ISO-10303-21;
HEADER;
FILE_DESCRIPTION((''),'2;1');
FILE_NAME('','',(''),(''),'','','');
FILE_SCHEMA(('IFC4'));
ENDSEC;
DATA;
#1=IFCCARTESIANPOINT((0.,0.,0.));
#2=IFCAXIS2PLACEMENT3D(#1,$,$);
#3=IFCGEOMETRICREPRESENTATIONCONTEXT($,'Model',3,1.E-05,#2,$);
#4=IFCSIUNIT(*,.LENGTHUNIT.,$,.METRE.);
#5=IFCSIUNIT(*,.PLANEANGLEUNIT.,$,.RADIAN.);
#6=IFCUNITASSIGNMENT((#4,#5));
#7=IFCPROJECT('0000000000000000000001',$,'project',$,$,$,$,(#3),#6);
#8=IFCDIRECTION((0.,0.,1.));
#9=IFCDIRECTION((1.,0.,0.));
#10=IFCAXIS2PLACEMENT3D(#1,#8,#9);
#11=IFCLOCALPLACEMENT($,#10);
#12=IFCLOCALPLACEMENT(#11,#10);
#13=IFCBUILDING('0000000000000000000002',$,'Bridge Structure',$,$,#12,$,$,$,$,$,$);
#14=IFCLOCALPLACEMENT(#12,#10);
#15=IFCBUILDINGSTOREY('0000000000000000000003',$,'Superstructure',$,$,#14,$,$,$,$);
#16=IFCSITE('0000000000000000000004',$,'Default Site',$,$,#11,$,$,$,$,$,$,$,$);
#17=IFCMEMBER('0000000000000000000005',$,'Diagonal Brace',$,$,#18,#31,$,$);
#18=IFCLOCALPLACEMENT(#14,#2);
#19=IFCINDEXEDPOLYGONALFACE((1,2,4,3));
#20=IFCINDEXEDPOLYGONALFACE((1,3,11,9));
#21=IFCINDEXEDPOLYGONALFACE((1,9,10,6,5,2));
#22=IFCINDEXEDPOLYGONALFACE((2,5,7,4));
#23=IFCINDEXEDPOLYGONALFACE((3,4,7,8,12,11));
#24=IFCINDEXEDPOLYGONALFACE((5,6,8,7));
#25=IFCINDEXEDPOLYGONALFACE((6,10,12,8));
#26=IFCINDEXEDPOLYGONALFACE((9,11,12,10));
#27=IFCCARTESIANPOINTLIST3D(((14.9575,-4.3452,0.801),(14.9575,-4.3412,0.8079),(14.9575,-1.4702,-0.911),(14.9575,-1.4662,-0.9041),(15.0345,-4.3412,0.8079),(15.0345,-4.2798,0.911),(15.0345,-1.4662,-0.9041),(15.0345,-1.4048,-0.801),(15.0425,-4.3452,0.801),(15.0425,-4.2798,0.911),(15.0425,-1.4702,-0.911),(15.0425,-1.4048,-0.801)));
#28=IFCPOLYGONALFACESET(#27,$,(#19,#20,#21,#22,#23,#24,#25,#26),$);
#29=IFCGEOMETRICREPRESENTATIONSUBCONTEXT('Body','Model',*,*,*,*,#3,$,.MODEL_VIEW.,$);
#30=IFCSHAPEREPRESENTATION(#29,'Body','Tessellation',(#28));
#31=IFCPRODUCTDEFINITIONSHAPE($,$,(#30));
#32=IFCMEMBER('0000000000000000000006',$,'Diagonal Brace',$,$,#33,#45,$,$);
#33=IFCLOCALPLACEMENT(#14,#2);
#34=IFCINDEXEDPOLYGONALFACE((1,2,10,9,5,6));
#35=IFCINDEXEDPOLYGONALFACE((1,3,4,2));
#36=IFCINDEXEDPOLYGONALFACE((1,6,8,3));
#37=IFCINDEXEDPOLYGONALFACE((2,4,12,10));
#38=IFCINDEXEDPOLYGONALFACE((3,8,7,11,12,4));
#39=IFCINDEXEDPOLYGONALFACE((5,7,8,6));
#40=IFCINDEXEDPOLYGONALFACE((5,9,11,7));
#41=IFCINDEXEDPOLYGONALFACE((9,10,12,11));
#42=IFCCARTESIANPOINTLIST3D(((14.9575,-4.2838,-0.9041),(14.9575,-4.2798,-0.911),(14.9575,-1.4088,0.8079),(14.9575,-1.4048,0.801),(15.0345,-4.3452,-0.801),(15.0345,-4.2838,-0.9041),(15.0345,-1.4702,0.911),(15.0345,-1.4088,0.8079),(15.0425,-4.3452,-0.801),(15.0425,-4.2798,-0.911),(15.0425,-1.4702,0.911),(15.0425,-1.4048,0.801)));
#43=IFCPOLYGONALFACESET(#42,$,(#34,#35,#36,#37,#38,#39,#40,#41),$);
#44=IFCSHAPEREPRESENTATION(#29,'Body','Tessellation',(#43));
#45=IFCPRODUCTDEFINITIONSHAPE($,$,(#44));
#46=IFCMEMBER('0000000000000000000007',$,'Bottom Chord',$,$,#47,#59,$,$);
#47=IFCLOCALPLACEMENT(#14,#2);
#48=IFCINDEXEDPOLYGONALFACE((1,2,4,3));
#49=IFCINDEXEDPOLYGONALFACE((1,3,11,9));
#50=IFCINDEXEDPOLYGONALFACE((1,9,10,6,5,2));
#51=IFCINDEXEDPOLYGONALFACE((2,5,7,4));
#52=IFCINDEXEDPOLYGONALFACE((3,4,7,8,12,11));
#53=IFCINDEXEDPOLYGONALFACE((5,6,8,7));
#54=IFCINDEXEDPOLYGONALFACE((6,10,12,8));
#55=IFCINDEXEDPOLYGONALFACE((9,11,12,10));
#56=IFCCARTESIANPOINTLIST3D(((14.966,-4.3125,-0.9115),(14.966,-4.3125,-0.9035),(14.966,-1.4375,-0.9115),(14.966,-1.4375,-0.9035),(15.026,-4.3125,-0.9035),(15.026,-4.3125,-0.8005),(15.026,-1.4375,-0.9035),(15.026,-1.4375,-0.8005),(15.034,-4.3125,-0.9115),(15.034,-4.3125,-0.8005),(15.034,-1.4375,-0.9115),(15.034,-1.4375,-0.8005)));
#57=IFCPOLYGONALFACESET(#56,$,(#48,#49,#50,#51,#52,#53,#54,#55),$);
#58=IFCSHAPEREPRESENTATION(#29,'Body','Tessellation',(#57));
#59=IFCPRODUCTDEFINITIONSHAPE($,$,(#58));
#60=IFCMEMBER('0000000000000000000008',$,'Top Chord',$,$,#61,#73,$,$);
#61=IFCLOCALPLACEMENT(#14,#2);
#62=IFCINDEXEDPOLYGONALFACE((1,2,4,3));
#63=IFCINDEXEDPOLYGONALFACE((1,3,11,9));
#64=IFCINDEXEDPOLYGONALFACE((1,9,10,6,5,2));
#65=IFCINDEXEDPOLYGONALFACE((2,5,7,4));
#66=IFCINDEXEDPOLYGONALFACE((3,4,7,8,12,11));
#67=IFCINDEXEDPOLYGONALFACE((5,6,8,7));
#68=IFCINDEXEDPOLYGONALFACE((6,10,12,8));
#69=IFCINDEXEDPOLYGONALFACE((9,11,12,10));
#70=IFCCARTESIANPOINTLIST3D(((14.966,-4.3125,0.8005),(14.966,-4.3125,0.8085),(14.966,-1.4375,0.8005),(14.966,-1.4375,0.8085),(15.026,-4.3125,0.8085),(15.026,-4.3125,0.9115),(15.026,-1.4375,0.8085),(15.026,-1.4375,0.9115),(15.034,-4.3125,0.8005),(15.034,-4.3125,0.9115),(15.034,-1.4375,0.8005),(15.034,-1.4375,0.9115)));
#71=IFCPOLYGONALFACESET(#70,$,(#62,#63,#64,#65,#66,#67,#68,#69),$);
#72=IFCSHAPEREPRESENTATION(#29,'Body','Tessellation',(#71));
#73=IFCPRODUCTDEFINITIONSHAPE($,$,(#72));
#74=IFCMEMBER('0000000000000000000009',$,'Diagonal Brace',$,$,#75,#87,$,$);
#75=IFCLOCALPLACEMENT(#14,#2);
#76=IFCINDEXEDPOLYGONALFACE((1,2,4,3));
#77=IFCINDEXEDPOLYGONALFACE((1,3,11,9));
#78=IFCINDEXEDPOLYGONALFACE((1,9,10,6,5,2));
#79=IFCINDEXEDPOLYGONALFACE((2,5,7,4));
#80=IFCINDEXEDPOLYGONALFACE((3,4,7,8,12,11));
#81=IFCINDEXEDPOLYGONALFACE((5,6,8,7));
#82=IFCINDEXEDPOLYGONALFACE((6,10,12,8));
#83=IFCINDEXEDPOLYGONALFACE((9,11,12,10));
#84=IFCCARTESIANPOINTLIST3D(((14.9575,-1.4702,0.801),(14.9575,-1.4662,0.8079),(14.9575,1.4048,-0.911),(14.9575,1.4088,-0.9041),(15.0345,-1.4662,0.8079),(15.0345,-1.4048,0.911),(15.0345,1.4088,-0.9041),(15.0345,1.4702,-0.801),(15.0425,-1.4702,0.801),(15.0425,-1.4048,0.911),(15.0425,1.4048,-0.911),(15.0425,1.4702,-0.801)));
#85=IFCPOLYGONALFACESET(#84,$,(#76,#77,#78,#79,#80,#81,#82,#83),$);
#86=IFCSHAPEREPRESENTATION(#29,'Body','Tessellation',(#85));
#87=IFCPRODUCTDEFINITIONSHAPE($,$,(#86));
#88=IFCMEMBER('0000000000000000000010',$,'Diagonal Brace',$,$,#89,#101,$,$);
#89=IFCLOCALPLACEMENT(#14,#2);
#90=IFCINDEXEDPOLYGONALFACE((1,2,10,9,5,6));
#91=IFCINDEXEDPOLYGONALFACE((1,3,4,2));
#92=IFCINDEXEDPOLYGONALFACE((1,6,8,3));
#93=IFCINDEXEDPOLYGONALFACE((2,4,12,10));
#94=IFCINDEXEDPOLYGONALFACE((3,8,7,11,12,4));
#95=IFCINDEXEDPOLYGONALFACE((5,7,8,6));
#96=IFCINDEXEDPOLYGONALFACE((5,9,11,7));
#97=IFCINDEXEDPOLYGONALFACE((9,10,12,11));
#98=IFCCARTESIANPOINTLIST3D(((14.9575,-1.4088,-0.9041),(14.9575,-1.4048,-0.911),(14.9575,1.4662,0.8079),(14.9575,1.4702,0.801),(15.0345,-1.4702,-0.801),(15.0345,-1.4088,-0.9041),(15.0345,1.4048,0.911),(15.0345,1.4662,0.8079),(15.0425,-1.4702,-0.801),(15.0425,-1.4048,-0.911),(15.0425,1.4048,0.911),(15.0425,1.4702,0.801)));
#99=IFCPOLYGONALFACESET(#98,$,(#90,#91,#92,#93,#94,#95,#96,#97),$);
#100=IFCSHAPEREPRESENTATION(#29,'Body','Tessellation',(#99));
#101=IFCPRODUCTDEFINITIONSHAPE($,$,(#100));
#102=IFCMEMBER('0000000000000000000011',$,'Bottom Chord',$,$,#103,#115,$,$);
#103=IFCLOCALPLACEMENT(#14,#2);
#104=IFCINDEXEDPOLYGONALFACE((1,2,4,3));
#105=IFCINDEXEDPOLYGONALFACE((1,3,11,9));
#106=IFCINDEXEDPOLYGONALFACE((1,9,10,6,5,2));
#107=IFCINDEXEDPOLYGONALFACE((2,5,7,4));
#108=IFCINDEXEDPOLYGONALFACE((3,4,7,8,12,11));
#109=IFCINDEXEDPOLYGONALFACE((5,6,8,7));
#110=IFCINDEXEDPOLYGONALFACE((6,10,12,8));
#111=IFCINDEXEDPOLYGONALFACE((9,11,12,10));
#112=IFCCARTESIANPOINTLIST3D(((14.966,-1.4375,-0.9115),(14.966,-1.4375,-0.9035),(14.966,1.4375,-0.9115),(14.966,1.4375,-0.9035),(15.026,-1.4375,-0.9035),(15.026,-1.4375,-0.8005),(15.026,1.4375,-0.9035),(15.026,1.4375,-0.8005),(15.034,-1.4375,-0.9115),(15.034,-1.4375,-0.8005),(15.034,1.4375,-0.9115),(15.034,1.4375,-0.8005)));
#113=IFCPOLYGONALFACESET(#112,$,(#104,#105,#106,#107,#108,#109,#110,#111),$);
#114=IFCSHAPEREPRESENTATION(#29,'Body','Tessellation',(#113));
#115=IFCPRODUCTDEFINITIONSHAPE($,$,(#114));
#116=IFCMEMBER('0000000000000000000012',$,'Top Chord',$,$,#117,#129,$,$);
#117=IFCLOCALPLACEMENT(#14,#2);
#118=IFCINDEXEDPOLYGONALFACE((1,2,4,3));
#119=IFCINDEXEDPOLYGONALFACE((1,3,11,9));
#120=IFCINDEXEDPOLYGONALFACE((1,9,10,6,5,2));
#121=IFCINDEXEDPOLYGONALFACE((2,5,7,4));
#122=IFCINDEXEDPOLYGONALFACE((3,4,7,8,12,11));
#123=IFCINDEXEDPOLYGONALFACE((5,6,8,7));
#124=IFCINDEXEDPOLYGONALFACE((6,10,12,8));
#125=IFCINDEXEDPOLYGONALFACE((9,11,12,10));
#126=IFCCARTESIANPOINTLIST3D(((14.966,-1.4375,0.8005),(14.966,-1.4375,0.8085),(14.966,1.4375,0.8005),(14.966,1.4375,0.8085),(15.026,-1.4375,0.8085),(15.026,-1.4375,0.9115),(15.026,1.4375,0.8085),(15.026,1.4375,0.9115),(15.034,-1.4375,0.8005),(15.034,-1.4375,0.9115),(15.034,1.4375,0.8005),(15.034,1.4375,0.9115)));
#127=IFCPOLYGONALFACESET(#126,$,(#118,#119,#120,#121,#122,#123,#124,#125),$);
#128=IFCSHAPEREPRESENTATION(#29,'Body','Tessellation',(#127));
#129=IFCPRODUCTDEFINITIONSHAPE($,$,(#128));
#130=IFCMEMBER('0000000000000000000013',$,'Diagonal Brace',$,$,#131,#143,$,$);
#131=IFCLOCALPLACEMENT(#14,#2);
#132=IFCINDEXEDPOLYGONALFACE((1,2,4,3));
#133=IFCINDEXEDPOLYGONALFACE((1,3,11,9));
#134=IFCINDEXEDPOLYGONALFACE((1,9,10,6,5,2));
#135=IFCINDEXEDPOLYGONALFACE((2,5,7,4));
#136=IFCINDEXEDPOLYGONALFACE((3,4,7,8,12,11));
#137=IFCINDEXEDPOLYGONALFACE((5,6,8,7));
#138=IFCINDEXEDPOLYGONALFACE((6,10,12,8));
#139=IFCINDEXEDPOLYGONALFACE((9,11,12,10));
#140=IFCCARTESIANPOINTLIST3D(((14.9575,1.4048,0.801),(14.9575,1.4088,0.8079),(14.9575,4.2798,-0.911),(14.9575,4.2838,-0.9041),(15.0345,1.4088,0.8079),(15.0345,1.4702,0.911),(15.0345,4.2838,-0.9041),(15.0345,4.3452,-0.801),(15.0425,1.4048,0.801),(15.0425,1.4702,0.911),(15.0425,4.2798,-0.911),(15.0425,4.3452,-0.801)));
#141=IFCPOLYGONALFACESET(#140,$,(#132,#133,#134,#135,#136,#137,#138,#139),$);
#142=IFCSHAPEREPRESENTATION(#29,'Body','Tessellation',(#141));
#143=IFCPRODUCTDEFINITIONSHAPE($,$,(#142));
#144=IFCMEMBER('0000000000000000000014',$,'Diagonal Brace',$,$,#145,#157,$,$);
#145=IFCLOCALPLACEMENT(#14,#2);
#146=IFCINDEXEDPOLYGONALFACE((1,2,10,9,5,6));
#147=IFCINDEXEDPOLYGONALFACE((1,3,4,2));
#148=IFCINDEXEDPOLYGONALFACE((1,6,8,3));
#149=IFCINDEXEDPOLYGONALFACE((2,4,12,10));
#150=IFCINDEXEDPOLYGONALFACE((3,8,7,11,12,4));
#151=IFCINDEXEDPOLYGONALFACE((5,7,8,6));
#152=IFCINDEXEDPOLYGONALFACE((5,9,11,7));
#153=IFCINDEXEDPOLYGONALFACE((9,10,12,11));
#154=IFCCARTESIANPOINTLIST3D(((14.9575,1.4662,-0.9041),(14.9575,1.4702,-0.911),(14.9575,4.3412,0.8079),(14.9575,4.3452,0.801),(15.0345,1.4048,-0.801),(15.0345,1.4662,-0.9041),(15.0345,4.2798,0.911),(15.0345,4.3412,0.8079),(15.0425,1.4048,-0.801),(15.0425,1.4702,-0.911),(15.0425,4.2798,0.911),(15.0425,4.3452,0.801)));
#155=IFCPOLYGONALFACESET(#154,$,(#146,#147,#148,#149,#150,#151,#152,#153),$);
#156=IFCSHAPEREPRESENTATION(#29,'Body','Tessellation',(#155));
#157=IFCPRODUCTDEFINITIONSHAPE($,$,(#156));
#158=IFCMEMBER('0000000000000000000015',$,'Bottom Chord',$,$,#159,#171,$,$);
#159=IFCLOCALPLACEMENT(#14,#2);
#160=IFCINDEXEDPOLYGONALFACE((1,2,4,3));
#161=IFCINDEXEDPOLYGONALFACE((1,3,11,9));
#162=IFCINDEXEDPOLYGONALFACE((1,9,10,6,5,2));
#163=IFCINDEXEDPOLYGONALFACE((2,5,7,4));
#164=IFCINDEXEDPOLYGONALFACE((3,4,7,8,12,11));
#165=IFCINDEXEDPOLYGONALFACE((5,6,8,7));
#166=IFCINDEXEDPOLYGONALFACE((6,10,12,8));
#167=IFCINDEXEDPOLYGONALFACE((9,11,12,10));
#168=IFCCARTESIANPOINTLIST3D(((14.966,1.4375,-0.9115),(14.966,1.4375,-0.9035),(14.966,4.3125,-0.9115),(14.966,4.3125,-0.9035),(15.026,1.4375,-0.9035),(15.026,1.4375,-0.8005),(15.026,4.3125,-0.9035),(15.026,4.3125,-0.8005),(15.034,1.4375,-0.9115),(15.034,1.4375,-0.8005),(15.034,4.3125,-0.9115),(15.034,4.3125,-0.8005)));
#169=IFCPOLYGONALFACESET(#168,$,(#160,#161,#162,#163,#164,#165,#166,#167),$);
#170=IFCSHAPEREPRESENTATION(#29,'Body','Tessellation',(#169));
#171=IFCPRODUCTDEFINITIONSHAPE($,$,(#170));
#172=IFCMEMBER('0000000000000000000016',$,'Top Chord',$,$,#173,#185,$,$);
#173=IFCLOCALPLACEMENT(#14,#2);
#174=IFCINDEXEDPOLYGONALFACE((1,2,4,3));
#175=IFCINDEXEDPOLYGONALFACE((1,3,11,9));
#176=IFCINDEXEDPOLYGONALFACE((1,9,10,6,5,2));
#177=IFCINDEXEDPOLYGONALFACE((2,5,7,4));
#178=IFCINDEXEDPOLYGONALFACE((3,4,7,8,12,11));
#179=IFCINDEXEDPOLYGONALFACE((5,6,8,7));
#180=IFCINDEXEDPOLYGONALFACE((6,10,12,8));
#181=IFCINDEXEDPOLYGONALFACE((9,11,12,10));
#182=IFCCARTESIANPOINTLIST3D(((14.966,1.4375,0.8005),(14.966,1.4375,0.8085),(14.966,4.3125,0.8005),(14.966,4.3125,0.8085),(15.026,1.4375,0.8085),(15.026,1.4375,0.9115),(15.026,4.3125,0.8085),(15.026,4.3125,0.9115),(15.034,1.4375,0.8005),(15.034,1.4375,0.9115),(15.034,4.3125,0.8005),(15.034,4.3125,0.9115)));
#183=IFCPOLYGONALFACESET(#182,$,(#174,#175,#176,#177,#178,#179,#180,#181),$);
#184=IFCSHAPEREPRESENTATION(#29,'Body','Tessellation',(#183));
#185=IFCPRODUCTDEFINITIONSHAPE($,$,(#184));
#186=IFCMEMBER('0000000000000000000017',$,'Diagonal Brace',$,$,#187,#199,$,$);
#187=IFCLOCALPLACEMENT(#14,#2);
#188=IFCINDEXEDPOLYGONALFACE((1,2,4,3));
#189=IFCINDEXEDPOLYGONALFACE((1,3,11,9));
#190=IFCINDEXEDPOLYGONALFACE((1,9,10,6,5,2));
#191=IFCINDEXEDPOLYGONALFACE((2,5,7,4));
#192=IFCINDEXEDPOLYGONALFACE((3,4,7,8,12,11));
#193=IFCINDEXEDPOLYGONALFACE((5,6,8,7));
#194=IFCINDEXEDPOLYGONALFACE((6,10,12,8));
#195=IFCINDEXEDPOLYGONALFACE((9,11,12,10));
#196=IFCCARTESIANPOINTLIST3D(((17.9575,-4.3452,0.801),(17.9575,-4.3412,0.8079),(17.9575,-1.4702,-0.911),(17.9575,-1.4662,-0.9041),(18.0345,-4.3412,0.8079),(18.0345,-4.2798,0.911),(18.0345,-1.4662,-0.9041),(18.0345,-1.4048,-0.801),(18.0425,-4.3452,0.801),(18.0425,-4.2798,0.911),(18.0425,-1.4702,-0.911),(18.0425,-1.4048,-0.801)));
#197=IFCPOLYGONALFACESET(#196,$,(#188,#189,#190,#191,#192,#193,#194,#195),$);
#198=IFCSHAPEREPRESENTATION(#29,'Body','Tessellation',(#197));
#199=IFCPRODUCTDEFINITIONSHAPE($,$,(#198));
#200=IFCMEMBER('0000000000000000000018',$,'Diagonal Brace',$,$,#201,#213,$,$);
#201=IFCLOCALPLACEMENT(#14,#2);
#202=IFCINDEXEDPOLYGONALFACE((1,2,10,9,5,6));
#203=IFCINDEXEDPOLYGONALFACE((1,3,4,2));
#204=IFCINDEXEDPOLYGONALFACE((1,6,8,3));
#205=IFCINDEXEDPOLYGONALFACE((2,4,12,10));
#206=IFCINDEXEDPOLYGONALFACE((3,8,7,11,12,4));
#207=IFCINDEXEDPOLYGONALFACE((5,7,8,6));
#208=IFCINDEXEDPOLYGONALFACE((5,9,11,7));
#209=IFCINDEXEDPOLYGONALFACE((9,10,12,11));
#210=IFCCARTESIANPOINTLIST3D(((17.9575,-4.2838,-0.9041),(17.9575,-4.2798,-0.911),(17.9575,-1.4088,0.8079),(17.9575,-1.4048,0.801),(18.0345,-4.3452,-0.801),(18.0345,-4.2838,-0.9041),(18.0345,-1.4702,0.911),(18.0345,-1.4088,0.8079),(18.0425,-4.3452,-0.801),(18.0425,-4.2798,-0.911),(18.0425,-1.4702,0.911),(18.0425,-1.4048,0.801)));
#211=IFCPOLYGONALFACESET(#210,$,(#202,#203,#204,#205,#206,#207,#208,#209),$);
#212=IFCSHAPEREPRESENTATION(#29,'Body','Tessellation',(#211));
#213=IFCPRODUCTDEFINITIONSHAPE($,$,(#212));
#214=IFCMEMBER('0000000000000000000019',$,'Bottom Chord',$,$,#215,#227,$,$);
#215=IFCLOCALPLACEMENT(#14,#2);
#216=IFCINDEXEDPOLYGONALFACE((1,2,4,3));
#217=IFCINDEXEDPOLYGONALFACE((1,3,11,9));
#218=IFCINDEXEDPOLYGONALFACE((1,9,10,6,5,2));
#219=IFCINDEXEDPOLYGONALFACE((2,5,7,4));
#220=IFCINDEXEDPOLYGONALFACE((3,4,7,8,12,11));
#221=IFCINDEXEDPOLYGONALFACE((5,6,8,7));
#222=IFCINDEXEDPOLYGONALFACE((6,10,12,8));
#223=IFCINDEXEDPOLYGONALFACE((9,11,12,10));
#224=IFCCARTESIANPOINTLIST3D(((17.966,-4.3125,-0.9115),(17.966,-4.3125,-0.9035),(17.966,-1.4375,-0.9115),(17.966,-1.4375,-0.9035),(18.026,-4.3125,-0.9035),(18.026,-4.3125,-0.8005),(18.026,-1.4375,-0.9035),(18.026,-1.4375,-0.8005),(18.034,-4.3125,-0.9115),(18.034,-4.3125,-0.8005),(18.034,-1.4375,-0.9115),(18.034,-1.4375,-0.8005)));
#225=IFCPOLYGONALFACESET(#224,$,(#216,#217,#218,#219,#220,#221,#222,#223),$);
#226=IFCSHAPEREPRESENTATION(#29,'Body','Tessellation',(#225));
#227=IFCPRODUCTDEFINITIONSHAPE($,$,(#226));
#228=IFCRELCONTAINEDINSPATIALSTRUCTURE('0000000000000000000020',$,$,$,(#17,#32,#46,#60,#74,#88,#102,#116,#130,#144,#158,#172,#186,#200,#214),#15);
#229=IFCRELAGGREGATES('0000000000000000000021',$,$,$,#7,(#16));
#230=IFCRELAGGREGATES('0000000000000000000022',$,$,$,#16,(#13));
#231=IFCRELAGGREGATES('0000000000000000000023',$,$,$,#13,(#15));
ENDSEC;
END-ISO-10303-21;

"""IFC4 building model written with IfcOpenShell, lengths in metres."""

from ifc_helpers import new_model, si_unit, frame, origin, origin_with_axes, origin_2d_with_axis, place, context, subcontext, project, spatial, l_section, extrude, element, save


model = new_model("IFC4")

# Units and contexts
model_context = context("Model", 3, precision=1e-05, world=origin())
body_context = subcontext(model_context, "Body", "Model", "MODEL_VIEW")
ifc_project = project(units=[si_unit("LENGTHUNIT", "METRE"), si_unit("PLANEANGLEUNIT", "RADIAN")], contexts=[model_context])

# Site, building, storey
site_placement = place(None, origin_with_axes())
site = spatial("IfcSite", under=ifc_project, at=site_placement, Name="Default Site")
building_placement = place(site_placement, origin_with_axes())
building = spatial("IfcBuilding", under=site, at=building_placement, Name="Bridge Structure")
storey_placement = place(building_placement, origin_with_axes())
storey = spatial("IfcBuildingStorey", under=building, at=storey_placement, Name="Superstructure")

# Members
for number, where, z_axis, x_axis, name in (
    (1, (15.0, -4.3125, 0.856), (0.0, 0.859202, -0.511636), (-1.0, 0.0, 0.0), "Diagonal Brace"),
    (2, (15.0, -4.3125, -0.856), (0.0, 0.859202, 0.511636), (-1.0, 0.0, 0.0), "Diagonal Brace"),
):
    element("IfcMember", number, at=place(storey_placement, frame(where, z_axis=z_axis, x_axis=x_axis)), inside=storey, Name=name, context=body_context, shape_type="SweptSolid", body=[
        extrude(l_section(Depth=0.128, Width=0.085, Thickness=0.008, at=origin_2d_with_axis()), origin_with_axes(), (0.0, 0.0, 1.0), 3.3461),
    ])
for number, where, z_axis, x_axis, name in (
    (3, (15.0, -4.3125, -0.856), (0.0, 1.0, 0.0), (-1.0, 0.0, 0.0), "Bottom Chord"),
    (4, (15.0, -4.3125, 0.856), (0.0, 1.0, 0.0), (-1.0, 0.0, 0.0), "Top Chord"),
):
    element("IfcMember", number, at=place(storey_placement, frame(where, z_axis=z_axis, x_axis=x_axis)), inside=storey, Name=name, context=body_context, shape_type="SweptSolid", body=[
        extrude(l_section(Depth=0.111, Width=0.068, Thickness=0.008, at=origin_2d_with_axis()), origin_with_axes(), (0.0, 0.0, 1.0), 2.875),
    ])
for number, where, z_axis, x_axis, name in (
    (5, (15.0, -1.4375, 0.856), (0.0, 0.859202, -0.511636), (-1.0, 0.0, 0.0), "Diagonal Brace"),
    (6, (15.0, -1.4375, -0.856), (0.0, 0.859202, 0.511636), (-1.0, 0.0, 0.0), "Diagonal Brace"),
):
    element("IfcMember", number, at=place(storey_placement, frame(where, z_axis=z_axis, x_axis=x_axis)), inside=storey, Name=name, context=body_context, shape_type="SweptSolid", body=[
        extrude(l_section(Depth=0.128, Width=0.085, Thickness=0.008, at=origin_2d_with_axis()), origin_with_axes(), (0.0, 0.0, 1.0), 3.3461),
    ])
for number, where, z_axis, x_axis, name in (
    (7, (15.0, -1.4375, -0.856), (0.0, 1.0, 0.0), (-1.0, 0.0, 0.0), "Bottom Chord"),
    (8, (15.0, -1.4375, 0.856), (0.0, 1.0, 0.0), (-1.0, 0.0, 0.0), "Top Chord"),
):
    element("IfcMember", number, at=place(storey_placement, frame(where, z_axis=z_axis, x_axis=x_axis)), inside=storey, Name=name, context=body_context, shape_type="SweptSolid", body=[
        extrude(l_section(Depth=0.111, Width=0.068, Thickness=0.008, at=origin_2d_with_axis()), origin_with_axes(), (0.0, 0.0, 1.0), 2.875),
    ])
for number, where, z_axis, x_axis, name in (
    (9, (15.0, 1.4375, 0.856), (0.0, 0.859202, -0.511636), (-1.0, 0.0, 0.0), "Diagonal Brace"),
    (10, (15.0, 1.4375, -0.856), (0.0, 0.859202, 0.511636), (-1.0, 0.0, 0.0), "Diagonal Brace"),
):
    element("IfcMember", number, at=place(storey_placement, frame(where, z_axis=z_axis, x_axis=x_axis)), inside=storey, Name=name, context=body_context, shape_type="SweptSolid", body=[
        extrude(l_section(Depth=0.128, Width=0.085, Thickness=0.008, at=origin_2d_with_axis()), origin_with_axes(), (0.0, 0.0, 1.0), 3.3461),
    ])
for number, where, z_axis, x_axis, name in (
    (11, (15.0, 1.4375, -0.856), (0.0, 1.0, 0.0), (-1.0, 0.0, 0.0), "Bottom Chord"),
    (12, (15.0, 1.4375, 0.856), (0.0, 1.0, 0.0), (-1.0, 0.0, 0.0), "Top Chord"),
):
    element("IfcMember", number, at=place(storey_placement, frame(where, z_axis=z_axis, x_axis=x_axis)), inside=storey, Name=name, context=body_context, shape_type="SweptSolid", body=[
        extrude(l_section(Depth=0.111, Width=0.068, Thickness=0.008, at=origin_2d_with_axis()), origin_with_axes(), (0.0, 0.0, 1.0), 2.875),
    ])
for number, where, z_axis, x_axis, name in (
    (13, (18.0, -4.3125, 0.856), (0.0, 0.859202, -0.511636), (-1.0, 0.0, 0.0), "Diagonal Brace"),
    (14, (18.0, -4.3125, -0.856), (0.0, 0.859202, 0.511636), (-1.0, 0.0, 0.0), "Diagonal Brace"),
):
    element("IfcMember", number, at=place(storey_placement, frame(where, z_axis=z_axis, x_axis=x_axis)), inside=storey, Name=name, context=body_context, shape_type="SweptSolid", body=[
        extrude(l_section(Depth=0.128, Width=0.085, Thickness=0.008, at=origin_2d_with_axis()), origin_with_axes(), (0.0, 0.0, 1.0), 3.3461),
    ])
for number, where, z_axis, x_axis, name in (
    (15, (18.0, -4.3125, -0.856), (0.0, 1.0, 0.0), (-1.0, 0.0, 0.0), "Bottom Chord"),
):
    element("IfcMember", number, at=place(storey_placement, frame(where, z_axis=z_axis, x_axis=x_axis)), inside=storey, Name=name, context=body_context, shape_type="SweptSolid", body=[
        extrude(l_section(Depth=0.111, Width=0.068, Thickness=0.008, at=origin_2d_with_axis()), origin_with_axes(), (0.0, 0.0, 1.0), 2.875),
    ])

save(model, "model.ifc")
